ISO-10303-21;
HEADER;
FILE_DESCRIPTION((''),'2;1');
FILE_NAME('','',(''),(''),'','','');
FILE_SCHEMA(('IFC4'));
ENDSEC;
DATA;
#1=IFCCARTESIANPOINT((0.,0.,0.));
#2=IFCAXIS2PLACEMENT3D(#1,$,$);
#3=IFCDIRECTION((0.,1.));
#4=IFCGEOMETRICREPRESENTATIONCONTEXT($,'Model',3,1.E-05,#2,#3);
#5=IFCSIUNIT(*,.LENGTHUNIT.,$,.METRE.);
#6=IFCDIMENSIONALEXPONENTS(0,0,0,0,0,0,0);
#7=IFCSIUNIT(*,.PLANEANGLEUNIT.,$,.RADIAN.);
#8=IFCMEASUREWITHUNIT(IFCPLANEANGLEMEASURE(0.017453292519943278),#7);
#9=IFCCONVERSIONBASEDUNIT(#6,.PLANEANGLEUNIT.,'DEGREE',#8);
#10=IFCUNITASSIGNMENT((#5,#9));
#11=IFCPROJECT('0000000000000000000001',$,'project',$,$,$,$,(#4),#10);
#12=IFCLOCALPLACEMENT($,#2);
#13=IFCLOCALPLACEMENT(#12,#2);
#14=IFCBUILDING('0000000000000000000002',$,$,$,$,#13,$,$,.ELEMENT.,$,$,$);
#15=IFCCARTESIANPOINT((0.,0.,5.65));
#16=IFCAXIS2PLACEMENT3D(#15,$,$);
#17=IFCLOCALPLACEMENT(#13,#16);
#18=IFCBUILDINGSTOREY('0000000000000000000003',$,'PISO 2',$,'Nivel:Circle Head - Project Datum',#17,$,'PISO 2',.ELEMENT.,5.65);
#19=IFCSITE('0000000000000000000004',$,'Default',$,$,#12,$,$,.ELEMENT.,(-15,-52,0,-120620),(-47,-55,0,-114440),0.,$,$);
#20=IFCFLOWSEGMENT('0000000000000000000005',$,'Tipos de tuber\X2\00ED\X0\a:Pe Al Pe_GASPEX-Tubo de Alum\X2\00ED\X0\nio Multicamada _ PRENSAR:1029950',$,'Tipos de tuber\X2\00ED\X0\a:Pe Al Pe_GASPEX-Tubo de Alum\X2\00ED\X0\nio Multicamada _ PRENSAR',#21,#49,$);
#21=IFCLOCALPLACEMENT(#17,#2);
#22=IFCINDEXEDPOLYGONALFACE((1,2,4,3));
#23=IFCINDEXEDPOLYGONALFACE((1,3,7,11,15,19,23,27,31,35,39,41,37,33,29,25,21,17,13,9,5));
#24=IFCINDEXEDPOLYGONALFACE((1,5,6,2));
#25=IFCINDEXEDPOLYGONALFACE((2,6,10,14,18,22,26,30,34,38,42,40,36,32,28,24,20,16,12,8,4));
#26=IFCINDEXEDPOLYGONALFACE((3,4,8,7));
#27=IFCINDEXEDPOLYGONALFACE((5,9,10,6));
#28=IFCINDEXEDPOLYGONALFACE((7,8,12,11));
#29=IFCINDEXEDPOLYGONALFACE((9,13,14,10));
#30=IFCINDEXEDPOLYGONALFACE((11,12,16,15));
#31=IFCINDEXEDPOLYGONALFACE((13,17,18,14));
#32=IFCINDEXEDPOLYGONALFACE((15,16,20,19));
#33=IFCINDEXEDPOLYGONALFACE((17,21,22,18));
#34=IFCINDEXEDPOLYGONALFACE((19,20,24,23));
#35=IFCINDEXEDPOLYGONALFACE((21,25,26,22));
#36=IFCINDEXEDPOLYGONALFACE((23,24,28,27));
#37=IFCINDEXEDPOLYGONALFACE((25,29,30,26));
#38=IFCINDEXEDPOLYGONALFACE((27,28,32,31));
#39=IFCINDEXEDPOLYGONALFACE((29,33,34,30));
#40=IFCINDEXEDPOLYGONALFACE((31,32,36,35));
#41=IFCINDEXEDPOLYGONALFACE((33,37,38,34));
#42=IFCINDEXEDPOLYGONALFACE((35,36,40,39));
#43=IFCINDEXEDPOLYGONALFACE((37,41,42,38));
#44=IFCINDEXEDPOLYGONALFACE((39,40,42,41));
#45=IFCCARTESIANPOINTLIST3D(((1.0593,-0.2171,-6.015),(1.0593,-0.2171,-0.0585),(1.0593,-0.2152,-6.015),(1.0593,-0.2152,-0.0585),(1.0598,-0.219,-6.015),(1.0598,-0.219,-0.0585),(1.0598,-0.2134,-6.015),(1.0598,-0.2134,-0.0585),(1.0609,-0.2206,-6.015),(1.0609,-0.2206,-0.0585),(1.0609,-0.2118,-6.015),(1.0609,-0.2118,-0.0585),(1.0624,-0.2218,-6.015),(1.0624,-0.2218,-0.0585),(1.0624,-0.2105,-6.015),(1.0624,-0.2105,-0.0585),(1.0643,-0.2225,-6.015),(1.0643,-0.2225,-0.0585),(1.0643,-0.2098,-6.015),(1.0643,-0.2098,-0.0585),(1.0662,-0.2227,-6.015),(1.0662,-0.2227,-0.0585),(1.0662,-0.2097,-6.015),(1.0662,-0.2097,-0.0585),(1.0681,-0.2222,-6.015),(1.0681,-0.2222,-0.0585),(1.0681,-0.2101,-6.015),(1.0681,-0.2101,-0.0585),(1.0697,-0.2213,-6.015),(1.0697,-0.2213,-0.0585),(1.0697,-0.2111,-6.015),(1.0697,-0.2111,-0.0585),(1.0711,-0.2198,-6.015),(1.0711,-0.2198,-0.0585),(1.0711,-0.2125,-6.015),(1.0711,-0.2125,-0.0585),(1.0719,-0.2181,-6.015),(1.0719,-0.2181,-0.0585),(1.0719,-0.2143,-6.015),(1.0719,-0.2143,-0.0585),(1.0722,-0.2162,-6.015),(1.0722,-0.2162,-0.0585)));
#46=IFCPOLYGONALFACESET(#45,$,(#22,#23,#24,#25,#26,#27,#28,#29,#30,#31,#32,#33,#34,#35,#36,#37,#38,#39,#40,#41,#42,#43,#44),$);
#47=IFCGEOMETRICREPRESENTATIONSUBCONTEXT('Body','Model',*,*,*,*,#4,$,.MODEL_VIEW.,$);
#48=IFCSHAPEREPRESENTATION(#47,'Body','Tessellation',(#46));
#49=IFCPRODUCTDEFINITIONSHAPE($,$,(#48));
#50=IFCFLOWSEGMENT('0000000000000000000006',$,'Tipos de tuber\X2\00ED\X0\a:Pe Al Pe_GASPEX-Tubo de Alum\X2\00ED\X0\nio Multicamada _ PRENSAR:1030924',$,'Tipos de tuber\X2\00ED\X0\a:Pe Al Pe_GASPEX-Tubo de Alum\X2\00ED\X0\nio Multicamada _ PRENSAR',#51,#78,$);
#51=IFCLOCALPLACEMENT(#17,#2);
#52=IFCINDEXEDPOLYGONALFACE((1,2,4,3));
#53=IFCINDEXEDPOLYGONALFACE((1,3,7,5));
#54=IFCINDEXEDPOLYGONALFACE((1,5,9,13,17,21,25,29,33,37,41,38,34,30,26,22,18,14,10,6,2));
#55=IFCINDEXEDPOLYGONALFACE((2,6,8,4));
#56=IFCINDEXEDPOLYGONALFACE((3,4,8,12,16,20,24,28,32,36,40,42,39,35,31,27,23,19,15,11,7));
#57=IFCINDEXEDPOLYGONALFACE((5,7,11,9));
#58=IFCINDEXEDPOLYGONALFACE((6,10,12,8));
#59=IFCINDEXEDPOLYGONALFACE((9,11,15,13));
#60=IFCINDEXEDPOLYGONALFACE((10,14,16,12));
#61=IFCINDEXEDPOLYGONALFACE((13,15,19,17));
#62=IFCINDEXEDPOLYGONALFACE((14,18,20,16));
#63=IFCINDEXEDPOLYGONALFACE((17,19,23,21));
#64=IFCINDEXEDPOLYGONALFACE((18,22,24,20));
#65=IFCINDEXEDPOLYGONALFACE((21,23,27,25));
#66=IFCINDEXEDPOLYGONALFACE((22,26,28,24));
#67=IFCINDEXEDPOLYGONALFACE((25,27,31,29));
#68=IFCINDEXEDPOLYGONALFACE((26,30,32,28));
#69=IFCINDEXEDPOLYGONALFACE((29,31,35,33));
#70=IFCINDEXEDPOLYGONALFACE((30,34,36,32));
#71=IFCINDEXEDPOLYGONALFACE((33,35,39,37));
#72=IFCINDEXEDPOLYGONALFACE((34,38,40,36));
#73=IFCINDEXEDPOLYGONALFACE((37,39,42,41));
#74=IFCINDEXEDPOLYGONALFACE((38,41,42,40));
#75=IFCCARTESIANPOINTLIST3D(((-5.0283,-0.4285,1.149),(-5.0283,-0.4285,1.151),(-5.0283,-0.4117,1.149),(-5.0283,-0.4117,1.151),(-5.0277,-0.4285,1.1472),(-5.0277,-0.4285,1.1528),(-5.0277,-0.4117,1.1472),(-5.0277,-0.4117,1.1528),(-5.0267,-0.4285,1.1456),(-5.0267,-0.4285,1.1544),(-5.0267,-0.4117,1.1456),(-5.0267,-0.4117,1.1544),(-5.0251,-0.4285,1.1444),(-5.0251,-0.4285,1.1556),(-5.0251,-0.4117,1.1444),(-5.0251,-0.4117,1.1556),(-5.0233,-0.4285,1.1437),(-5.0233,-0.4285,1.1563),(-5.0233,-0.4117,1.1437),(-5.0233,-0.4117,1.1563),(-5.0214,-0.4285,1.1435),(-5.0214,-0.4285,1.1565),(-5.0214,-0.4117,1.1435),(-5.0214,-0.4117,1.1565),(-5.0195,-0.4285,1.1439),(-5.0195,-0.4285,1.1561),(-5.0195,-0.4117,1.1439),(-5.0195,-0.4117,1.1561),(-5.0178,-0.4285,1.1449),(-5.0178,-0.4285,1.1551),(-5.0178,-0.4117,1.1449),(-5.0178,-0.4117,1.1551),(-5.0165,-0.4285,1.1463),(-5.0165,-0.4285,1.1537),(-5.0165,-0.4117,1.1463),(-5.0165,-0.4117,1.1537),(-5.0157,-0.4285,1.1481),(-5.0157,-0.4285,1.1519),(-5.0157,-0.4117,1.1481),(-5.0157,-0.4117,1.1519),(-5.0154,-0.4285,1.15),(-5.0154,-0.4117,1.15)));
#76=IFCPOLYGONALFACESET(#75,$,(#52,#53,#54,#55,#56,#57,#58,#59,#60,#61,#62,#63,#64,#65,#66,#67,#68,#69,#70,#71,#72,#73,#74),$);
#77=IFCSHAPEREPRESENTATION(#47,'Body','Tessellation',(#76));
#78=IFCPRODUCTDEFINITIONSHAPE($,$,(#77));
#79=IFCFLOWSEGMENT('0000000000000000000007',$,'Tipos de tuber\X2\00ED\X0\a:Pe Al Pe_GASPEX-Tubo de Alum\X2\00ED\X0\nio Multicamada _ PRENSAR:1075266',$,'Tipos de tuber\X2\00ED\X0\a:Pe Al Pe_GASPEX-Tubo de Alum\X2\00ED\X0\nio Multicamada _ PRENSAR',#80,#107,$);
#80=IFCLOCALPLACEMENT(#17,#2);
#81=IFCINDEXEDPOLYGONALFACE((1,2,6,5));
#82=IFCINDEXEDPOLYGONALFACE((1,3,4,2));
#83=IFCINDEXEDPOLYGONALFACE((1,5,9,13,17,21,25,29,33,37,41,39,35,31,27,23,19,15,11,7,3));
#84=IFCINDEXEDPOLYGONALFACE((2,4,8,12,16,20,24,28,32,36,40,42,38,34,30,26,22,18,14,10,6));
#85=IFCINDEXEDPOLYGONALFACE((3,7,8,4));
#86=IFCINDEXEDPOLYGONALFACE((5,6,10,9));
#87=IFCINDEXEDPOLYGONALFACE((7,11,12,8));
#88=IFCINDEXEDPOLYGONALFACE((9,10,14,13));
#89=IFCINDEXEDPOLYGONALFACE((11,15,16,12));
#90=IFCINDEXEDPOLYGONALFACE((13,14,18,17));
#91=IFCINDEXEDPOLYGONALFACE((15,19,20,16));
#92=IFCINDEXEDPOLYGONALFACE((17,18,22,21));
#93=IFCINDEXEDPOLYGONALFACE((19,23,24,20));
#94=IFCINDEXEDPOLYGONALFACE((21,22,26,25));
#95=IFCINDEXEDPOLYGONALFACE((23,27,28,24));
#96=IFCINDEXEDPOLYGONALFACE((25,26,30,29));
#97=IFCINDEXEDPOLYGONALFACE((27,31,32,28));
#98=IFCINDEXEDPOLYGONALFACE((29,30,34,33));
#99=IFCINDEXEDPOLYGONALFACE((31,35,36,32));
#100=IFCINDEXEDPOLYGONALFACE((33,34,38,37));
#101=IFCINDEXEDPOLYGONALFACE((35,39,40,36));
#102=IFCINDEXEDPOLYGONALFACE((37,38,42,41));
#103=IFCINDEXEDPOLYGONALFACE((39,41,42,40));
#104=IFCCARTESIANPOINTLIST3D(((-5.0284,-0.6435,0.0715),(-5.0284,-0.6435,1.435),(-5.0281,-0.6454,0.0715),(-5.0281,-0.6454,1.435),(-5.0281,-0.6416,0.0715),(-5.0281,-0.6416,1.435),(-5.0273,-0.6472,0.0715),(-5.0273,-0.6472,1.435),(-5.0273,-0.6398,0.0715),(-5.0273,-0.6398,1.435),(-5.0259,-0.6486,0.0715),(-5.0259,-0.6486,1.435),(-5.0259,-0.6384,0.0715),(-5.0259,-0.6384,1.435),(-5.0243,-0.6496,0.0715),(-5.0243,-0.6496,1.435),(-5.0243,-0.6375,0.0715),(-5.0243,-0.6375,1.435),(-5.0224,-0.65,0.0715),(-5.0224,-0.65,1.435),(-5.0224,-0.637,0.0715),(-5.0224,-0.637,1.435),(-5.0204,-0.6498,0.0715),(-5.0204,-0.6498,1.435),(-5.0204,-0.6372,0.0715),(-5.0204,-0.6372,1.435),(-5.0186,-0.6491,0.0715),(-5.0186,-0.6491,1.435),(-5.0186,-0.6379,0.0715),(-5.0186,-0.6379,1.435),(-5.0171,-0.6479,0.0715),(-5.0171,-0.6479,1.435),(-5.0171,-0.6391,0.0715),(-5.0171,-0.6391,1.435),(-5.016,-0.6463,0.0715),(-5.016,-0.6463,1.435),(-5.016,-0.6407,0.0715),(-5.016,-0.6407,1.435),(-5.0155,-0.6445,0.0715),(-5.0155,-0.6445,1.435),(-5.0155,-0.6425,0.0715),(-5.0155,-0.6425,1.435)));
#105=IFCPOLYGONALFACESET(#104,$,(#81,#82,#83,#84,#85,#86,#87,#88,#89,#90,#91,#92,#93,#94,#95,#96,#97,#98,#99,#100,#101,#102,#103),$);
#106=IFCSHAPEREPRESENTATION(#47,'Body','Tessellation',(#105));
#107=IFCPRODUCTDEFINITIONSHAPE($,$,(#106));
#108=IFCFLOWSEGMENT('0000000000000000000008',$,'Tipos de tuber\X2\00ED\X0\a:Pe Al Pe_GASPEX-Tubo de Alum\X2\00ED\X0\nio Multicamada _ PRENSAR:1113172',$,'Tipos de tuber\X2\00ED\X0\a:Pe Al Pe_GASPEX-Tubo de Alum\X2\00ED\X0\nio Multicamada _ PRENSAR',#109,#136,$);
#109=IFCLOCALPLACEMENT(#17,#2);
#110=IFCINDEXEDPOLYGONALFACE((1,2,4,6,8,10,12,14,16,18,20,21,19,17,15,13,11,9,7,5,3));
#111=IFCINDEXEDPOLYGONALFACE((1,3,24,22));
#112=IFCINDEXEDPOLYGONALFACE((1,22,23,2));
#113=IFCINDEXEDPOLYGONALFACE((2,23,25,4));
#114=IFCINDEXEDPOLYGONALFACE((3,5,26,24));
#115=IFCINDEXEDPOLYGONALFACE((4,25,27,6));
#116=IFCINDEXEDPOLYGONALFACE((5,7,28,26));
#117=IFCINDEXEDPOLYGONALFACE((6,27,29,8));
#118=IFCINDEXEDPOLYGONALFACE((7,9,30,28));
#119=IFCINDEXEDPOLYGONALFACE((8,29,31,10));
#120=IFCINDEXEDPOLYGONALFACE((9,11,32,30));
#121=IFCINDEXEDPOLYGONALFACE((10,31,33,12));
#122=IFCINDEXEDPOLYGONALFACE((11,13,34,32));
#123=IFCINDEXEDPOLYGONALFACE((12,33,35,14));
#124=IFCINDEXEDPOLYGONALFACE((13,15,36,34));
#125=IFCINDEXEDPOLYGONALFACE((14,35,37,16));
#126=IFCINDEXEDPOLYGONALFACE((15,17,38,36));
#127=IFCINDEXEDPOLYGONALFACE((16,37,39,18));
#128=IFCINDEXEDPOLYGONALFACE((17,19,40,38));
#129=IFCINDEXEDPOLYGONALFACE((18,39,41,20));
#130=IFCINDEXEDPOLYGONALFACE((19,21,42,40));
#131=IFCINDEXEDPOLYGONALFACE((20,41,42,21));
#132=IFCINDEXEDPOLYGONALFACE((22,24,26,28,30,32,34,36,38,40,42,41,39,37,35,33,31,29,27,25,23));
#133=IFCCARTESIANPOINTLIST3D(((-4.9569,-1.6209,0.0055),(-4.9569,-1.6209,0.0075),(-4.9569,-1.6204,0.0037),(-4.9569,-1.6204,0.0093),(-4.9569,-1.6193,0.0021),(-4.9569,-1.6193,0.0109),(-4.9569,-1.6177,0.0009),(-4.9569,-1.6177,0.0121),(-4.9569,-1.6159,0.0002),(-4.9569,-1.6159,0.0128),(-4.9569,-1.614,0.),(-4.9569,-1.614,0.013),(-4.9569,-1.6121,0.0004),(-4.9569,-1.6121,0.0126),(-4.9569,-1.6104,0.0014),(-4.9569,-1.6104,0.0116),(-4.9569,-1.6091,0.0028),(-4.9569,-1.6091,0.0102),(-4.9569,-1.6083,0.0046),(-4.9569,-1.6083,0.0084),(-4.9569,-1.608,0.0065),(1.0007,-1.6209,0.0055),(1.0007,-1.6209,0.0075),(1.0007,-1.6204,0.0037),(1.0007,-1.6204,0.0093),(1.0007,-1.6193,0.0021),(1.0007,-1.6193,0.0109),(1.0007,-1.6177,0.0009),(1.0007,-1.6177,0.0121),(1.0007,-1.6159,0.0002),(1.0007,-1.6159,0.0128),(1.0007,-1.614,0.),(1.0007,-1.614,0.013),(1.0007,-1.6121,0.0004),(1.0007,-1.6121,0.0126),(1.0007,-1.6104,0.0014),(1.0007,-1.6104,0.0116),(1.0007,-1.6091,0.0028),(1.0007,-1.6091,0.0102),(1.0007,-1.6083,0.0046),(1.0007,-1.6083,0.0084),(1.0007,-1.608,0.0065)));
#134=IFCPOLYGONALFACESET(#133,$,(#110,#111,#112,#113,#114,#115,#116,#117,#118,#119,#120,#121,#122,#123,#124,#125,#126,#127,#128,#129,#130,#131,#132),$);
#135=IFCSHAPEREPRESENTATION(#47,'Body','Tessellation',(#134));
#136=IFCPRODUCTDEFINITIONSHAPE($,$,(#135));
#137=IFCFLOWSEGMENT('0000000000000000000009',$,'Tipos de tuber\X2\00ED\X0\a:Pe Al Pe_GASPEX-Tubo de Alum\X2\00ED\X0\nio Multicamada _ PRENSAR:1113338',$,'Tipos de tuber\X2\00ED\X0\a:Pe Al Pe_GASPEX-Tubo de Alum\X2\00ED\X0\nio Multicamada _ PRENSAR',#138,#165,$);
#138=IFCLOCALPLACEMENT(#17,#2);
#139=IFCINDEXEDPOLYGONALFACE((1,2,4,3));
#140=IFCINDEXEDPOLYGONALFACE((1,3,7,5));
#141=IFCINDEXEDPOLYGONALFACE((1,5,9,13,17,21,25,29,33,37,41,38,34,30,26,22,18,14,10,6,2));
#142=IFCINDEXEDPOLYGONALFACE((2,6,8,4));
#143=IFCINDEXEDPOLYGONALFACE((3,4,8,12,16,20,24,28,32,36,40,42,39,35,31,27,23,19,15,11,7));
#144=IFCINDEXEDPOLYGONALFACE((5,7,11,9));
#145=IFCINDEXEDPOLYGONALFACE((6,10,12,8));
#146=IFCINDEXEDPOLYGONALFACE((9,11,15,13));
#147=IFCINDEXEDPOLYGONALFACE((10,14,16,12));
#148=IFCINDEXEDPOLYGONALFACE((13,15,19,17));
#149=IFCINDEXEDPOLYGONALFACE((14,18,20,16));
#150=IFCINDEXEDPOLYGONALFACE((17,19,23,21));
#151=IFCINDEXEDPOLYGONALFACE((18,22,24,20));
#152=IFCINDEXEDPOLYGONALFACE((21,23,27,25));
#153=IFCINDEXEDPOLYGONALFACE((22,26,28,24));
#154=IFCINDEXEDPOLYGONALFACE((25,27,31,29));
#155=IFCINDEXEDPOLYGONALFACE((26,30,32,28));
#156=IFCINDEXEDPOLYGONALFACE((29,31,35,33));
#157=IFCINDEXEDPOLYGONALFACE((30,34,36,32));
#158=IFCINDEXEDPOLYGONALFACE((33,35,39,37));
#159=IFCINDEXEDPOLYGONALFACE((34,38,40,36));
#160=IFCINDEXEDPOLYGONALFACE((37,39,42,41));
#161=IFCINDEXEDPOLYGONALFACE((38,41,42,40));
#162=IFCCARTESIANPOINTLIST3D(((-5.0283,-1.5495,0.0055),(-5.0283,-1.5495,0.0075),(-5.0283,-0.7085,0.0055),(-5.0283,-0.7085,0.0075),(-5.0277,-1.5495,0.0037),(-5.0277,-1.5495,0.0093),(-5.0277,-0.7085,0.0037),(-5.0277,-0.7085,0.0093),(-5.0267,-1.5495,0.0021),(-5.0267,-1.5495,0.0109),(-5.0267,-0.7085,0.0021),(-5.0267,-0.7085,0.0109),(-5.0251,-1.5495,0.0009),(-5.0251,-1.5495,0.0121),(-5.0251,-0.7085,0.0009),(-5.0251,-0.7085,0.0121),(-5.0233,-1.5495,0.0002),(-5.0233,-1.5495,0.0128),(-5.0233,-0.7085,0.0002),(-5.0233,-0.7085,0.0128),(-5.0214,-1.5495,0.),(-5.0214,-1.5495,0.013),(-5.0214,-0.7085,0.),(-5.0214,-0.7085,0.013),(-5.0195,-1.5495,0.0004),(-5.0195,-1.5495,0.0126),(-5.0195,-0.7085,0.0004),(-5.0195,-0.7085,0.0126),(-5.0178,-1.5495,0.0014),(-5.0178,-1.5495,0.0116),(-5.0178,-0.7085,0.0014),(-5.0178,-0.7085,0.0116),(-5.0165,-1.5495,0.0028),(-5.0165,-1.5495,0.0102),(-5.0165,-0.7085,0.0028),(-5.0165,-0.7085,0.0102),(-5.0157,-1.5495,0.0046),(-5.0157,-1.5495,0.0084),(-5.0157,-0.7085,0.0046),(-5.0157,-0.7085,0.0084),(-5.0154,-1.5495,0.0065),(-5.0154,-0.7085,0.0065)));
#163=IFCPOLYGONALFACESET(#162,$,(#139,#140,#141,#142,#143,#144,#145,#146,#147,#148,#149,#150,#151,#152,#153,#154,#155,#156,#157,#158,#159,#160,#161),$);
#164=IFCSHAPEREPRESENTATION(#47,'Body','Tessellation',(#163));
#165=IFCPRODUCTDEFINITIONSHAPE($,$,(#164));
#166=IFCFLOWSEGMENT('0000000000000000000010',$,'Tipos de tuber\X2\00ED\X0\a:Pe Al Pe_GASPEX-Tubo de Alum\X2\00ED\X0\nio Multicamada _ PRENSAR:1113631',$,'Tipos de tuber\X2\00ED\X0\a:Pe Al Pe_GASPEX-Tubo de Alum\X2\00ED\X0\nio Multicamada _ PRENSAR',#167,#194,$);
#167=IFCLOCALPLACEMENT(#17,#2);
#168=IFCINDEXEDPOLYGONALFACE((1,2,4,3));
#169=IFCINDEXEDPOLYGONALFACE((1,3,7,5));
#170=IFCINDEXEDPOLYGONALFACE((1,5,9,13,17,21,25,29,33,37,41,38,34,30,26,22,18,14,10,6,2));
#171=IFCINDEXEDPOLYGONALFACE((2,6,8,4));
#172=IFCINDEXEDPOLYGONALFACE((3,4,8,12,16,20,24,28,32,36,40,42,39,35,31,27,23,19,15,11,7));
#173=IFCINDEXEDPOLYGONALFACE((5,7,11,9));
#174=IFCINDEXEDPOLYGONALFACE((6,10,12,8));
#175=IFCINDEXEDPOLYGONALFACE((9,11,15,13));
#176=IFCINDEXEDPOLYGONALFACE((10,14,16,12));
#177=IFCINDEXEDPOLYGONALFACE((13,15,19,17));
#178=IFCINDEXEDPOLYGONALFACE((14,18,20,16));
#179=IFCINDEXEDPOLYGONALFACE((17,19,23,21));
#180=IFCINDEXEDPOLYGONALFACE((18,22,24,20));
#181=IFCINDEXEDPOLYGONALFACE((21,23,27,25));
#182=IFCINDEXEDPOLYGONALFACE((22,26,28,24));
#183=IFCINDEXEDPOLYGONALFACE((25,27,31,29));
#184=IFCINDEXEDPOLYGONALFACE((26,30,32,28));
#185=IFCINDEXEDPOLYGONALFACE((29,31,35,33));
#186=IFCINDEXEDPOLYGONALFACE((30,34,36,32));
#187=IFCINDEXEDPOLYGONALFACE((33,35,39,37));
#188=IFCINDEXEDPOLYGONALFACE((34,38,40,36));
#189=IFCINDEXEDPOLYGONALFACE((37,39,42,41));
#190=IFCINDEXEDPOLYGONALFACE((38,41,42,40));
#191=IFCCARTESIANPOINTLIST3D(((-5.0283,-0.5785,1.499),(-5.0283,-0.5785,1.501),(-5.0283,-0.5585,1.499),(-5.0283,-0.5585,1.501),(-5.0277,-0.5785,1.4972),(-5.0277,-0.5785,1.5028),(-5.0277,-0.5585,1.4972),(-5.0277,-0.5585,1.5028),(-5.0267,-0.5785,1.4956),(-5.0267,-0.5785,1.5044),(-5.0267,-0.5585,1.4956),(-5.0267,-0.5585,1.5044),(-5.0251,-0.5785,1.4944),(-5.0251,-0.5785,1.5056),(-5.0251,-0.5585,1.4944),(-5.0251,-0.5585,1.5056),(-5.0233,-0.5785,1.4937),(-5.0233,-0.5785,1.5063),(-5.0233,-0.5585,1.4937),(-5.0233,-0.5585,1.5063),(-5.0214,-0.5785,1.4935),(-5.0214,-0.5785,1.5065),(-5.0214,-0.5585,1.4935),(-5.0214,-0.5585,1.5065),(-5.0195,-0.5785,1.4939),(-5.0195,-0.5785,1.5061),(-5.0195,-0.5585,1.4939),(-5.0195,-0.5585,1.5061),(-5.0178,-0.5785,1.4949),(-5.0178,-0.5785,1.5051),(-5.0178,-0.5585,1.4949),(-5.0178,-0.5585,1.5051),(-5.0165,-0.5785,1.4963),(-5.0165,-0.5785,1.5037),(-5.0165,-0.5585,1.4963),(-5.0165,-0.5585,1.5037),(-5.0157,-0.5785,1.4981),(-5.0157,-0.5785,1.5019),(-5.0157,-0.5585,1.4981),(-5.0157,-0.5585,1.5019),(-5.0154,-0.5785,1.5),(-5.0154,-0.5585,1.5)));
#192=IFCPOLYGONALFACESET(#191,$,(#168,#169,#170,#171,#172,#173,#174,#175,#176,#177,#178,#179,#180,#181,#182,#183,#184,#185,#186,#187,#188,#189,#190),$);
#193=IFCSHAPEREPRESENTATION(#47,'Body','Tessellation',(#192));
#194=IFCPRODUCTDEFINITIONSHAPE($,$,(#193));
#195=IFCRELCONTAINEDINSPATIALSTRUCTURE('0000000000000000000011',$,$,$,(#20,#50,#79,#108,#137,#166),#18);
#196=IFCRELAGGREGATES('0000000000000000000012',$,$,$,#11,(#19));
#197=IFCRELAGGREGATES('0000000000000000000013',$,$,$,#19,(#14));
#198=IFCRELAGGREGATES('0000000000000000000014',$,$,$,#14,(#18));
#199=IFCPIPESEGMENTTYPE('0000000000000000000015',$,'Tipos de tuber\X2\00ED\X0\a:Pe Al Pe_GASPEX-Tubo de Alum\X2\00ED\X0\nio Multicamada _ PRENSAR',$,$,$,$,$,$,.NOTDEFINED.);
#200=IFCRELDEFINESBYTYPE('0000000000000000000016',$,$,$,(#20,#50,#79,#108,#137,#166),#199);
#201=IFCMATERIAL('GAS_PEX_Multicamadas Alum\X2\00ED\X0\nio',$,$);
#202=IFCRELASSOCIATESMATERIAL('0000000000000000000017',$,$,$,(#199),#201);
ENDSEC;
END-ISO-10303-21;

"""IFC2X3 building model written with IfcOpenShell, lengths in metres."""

from ifc_helpers import new_model, entity, si_unit, converted_unit, direction, frame, frame_2d, origin, origin_2d_with_axis, place, context, subcontext, project, spatial, circle, extrude, material, type_object, element, save


model = new_model("IFC2X3")

# Units and contexts
model_context = context("Model", 3, precision=1e-05, world=origin(), true_north=direction((0.0, 1.0)))
body_context = subcontext(model_context, "Body", "Model", "MODEL_VIEW")
ifc_project = project(units=[si_unit("LENGTHUNIT", "METRE"), converted_unit("PLANEANGLEUNIT", "DEGREE", entity("IfcPlaneAngleMeasure", 0.017453292519943278), si_unit("PLANEANGLEUNIT", "RADIAN"), dimensions=[0, 0, 0, 0, 0, 0, 0])], contexts=[model_context])

# Site, building, storey
site_placement = place(None, origin())
site = spatial("IfcSite", under=ifc_project, at=site_placement, Name="Default", CompositionType="ELEMENT", RefLatitude=(-15, -52, 0, -120620), RefLongitude=(-47, -55, 0, -114440), RefElevation=0.0)
building_placement = place(site_placement, origin())
building = spatial("IfcBuilding", under=site, at=building_placement, CompositionType="ELEMENT")
storey_placement = place(building_placement, frame((0.0, 0.0, 5.65)))
storey = spatial("IfcBuildingStorey", under=building, at=storey_placement, Name="PISO 2", ObjectType="Nivel:Circle Head - Project Datum", LongName="PISO 2", CompositionType="ELEMENT", Elevation=5.65)

# Flow segments
ifc_material = material(Name="GAS_PEX_Multicamadas Alumínio")
pipe_segment_type = type_object("IfcPipeSegmentType", Name="Tipos de tubería:Pe Al Pe_GASPEX-Tubo de Alumínio Multicamada _ PRENSAR", PredefinedType="NOTDEFINED", material=ifc_material)
flow_segment_1_placement = place(storey_placement, origin())
element("IfcFlowSegment", 1, at=flow_segment_1_placement, inside=storey, type_object=pipe_segment_type, Name="Tipos de tubería:Pe Al Pe_GASPEX-Tubo de Alumínio Multicamada _ PRENSAR:1029950", ObjectType="Tipos de tubería:Pe Al Pe_GASPEX-Tubo de Alumínio Multicamada _ PRENSAR", context=body_context, shape_type="SweptSolid", body=[
    extrude(circle(Radius=0.0065, at=frame_2d((0.0, 0.0), x_axis=(1.0, 0.0))), frame((1.0657, -0.2162, -6.015)), (0.0, 0.0, 1.0), 5.9565),
])
flow_segment_2_placement = place(storey_placement, origin())
element("IfcFlowSegment", 2, at=flow_segment_2_placement, inside=storey, type_object=pipe_segment_type, Name="Tipos de tubería:Pe Al Pe_GASPEX-Tubo de Alumínio Multicamada _ PRENSAR:1030924", ObjectType="Tipos de tubería:Pe Al Pe_GASPEX-Tubo de Alumínio Multicamada _ PRENSAR", context=body_context, shape_type="SweptSolid", body=[
    extrude(circle(Radius=0.0065, at=origin_2d_with_axis()), frame((-5.0219, -0.4285, 1.15), z_axis=(0.0, 1.0, 0.0), x_axis=(1.0, 0.0, 0.0)), (0.0, 0.0, 1.0), 0.0168),
])
flow_segment_3_placement = place(storey_placement, origin())
element("IfcFlowSegment", 3, at=flow_segment_3_placement, inside=storey, type_object=pipe_segment_type, Name="Tipos de tubería:Pe Al Pe_GASPEX-Tubo de Alumínio Multicamada _ PRENSAR:1075266", ObjectType="Tipos de tubería:Pe Al Pe_GASPEX-Tubo de Alumínio Multicamada _ PRENSAR", context=body_context, shape_type="SweptSolid", body=[
    extrude(circle(Radius=0.0065, at=origin_2d_with_axis()), frame((-5.0219, -0.6435, 0.0715), z_axis=(0.0, 0.0, 1.0), x_axis=(-1.0, 0.0, 0.0)), (0.0, 0.0, 1.0), 1.3635),
])
flow_segment_4_placement = place(storey_placement, origin())
element("IfcFlowSegment", 4, at=flow_segment_4_placement, inside=storey, type_object=pipe_segment_type, Name="Tipos de tubería:Pe Al Pe_GASPEX-Tubo de Alumínio Multicamada _ PRENSAR:1113172", ObjectType="Tipos de tubería:Pe Al Pe_GASPEX-Tubo de Alumínio Multicamada _ PRENSAR", context=body_context, shape_type="SweptSolid", body=[
    extrude(circle(Radius=0.0065, at=frame_2d((0.0, 0.0), x_axis=(1.0, 0.0))), frame((-4.9569, -1.6145, 0.0065), z_axis=(1.0, 0.0, 0.0), x_axis=(0.0, 1.0, 0.0)), (0.0, 0.0, 1.0), 5.9576),
])
flow_segment_5_placement = place(storey_placement, origin())
element("IfcFlowSegment", 5, at=flow_segment_5_placement, inside=storey, type_object=pipe_segment_type, Name="Tipos de tubería:Pe Al Pe_GASPEX-Tubo de Alumínio Multicamada _ PRENSAR:1113338", ObjectType="Tipos de tubería:Pe Al Pe_GASPEX-Tubo de Alumínio Multicamada _ PRENSAR", context=body_context, shape_type="SweptSolid", body=[
    extrude(circle(Radius=0.0065, at=origin_2d_with_axis()), frame((-5.0219, -1.5495, 0.0065), z_axis=(0.0, 1.0, 0.0), x_axis=(1.0, 0.0, 0.0)), (0.0, 0.0, 1.0), 0.841),
])
flow_segment_6_placement = place(storey_placement, origin())
element("IfcFlowSegment", 6, at=flow_segment_6_placement, inside=storey, type_object=pipe_segment_type, Name="Tipos de tubería:Pe Al Pe_GASPEX-Tubo de Alumínio Multicamada _ PRENSAR:1113631", ObjectType="Tipos de tubería:Pe Al Pe_GASPEX-Tubo de Alumínio Multicamada _ PRENSAR", context=body_context, shape_type="SweptSolid", body=[
    extrude(circle(Radius=0.0065, at=frame_2d((0.0, 0.0), x_axis=(1.0, 0.0))), frame((-5.0219, -0.5785, 1.5), z_axis=(0.0, 1.0, 0.0), x_axis=(1.0, 0.0, 0.0)), (0.0, 0.0, 1.0), 0.02),
])

save(model, "model.ifc")
